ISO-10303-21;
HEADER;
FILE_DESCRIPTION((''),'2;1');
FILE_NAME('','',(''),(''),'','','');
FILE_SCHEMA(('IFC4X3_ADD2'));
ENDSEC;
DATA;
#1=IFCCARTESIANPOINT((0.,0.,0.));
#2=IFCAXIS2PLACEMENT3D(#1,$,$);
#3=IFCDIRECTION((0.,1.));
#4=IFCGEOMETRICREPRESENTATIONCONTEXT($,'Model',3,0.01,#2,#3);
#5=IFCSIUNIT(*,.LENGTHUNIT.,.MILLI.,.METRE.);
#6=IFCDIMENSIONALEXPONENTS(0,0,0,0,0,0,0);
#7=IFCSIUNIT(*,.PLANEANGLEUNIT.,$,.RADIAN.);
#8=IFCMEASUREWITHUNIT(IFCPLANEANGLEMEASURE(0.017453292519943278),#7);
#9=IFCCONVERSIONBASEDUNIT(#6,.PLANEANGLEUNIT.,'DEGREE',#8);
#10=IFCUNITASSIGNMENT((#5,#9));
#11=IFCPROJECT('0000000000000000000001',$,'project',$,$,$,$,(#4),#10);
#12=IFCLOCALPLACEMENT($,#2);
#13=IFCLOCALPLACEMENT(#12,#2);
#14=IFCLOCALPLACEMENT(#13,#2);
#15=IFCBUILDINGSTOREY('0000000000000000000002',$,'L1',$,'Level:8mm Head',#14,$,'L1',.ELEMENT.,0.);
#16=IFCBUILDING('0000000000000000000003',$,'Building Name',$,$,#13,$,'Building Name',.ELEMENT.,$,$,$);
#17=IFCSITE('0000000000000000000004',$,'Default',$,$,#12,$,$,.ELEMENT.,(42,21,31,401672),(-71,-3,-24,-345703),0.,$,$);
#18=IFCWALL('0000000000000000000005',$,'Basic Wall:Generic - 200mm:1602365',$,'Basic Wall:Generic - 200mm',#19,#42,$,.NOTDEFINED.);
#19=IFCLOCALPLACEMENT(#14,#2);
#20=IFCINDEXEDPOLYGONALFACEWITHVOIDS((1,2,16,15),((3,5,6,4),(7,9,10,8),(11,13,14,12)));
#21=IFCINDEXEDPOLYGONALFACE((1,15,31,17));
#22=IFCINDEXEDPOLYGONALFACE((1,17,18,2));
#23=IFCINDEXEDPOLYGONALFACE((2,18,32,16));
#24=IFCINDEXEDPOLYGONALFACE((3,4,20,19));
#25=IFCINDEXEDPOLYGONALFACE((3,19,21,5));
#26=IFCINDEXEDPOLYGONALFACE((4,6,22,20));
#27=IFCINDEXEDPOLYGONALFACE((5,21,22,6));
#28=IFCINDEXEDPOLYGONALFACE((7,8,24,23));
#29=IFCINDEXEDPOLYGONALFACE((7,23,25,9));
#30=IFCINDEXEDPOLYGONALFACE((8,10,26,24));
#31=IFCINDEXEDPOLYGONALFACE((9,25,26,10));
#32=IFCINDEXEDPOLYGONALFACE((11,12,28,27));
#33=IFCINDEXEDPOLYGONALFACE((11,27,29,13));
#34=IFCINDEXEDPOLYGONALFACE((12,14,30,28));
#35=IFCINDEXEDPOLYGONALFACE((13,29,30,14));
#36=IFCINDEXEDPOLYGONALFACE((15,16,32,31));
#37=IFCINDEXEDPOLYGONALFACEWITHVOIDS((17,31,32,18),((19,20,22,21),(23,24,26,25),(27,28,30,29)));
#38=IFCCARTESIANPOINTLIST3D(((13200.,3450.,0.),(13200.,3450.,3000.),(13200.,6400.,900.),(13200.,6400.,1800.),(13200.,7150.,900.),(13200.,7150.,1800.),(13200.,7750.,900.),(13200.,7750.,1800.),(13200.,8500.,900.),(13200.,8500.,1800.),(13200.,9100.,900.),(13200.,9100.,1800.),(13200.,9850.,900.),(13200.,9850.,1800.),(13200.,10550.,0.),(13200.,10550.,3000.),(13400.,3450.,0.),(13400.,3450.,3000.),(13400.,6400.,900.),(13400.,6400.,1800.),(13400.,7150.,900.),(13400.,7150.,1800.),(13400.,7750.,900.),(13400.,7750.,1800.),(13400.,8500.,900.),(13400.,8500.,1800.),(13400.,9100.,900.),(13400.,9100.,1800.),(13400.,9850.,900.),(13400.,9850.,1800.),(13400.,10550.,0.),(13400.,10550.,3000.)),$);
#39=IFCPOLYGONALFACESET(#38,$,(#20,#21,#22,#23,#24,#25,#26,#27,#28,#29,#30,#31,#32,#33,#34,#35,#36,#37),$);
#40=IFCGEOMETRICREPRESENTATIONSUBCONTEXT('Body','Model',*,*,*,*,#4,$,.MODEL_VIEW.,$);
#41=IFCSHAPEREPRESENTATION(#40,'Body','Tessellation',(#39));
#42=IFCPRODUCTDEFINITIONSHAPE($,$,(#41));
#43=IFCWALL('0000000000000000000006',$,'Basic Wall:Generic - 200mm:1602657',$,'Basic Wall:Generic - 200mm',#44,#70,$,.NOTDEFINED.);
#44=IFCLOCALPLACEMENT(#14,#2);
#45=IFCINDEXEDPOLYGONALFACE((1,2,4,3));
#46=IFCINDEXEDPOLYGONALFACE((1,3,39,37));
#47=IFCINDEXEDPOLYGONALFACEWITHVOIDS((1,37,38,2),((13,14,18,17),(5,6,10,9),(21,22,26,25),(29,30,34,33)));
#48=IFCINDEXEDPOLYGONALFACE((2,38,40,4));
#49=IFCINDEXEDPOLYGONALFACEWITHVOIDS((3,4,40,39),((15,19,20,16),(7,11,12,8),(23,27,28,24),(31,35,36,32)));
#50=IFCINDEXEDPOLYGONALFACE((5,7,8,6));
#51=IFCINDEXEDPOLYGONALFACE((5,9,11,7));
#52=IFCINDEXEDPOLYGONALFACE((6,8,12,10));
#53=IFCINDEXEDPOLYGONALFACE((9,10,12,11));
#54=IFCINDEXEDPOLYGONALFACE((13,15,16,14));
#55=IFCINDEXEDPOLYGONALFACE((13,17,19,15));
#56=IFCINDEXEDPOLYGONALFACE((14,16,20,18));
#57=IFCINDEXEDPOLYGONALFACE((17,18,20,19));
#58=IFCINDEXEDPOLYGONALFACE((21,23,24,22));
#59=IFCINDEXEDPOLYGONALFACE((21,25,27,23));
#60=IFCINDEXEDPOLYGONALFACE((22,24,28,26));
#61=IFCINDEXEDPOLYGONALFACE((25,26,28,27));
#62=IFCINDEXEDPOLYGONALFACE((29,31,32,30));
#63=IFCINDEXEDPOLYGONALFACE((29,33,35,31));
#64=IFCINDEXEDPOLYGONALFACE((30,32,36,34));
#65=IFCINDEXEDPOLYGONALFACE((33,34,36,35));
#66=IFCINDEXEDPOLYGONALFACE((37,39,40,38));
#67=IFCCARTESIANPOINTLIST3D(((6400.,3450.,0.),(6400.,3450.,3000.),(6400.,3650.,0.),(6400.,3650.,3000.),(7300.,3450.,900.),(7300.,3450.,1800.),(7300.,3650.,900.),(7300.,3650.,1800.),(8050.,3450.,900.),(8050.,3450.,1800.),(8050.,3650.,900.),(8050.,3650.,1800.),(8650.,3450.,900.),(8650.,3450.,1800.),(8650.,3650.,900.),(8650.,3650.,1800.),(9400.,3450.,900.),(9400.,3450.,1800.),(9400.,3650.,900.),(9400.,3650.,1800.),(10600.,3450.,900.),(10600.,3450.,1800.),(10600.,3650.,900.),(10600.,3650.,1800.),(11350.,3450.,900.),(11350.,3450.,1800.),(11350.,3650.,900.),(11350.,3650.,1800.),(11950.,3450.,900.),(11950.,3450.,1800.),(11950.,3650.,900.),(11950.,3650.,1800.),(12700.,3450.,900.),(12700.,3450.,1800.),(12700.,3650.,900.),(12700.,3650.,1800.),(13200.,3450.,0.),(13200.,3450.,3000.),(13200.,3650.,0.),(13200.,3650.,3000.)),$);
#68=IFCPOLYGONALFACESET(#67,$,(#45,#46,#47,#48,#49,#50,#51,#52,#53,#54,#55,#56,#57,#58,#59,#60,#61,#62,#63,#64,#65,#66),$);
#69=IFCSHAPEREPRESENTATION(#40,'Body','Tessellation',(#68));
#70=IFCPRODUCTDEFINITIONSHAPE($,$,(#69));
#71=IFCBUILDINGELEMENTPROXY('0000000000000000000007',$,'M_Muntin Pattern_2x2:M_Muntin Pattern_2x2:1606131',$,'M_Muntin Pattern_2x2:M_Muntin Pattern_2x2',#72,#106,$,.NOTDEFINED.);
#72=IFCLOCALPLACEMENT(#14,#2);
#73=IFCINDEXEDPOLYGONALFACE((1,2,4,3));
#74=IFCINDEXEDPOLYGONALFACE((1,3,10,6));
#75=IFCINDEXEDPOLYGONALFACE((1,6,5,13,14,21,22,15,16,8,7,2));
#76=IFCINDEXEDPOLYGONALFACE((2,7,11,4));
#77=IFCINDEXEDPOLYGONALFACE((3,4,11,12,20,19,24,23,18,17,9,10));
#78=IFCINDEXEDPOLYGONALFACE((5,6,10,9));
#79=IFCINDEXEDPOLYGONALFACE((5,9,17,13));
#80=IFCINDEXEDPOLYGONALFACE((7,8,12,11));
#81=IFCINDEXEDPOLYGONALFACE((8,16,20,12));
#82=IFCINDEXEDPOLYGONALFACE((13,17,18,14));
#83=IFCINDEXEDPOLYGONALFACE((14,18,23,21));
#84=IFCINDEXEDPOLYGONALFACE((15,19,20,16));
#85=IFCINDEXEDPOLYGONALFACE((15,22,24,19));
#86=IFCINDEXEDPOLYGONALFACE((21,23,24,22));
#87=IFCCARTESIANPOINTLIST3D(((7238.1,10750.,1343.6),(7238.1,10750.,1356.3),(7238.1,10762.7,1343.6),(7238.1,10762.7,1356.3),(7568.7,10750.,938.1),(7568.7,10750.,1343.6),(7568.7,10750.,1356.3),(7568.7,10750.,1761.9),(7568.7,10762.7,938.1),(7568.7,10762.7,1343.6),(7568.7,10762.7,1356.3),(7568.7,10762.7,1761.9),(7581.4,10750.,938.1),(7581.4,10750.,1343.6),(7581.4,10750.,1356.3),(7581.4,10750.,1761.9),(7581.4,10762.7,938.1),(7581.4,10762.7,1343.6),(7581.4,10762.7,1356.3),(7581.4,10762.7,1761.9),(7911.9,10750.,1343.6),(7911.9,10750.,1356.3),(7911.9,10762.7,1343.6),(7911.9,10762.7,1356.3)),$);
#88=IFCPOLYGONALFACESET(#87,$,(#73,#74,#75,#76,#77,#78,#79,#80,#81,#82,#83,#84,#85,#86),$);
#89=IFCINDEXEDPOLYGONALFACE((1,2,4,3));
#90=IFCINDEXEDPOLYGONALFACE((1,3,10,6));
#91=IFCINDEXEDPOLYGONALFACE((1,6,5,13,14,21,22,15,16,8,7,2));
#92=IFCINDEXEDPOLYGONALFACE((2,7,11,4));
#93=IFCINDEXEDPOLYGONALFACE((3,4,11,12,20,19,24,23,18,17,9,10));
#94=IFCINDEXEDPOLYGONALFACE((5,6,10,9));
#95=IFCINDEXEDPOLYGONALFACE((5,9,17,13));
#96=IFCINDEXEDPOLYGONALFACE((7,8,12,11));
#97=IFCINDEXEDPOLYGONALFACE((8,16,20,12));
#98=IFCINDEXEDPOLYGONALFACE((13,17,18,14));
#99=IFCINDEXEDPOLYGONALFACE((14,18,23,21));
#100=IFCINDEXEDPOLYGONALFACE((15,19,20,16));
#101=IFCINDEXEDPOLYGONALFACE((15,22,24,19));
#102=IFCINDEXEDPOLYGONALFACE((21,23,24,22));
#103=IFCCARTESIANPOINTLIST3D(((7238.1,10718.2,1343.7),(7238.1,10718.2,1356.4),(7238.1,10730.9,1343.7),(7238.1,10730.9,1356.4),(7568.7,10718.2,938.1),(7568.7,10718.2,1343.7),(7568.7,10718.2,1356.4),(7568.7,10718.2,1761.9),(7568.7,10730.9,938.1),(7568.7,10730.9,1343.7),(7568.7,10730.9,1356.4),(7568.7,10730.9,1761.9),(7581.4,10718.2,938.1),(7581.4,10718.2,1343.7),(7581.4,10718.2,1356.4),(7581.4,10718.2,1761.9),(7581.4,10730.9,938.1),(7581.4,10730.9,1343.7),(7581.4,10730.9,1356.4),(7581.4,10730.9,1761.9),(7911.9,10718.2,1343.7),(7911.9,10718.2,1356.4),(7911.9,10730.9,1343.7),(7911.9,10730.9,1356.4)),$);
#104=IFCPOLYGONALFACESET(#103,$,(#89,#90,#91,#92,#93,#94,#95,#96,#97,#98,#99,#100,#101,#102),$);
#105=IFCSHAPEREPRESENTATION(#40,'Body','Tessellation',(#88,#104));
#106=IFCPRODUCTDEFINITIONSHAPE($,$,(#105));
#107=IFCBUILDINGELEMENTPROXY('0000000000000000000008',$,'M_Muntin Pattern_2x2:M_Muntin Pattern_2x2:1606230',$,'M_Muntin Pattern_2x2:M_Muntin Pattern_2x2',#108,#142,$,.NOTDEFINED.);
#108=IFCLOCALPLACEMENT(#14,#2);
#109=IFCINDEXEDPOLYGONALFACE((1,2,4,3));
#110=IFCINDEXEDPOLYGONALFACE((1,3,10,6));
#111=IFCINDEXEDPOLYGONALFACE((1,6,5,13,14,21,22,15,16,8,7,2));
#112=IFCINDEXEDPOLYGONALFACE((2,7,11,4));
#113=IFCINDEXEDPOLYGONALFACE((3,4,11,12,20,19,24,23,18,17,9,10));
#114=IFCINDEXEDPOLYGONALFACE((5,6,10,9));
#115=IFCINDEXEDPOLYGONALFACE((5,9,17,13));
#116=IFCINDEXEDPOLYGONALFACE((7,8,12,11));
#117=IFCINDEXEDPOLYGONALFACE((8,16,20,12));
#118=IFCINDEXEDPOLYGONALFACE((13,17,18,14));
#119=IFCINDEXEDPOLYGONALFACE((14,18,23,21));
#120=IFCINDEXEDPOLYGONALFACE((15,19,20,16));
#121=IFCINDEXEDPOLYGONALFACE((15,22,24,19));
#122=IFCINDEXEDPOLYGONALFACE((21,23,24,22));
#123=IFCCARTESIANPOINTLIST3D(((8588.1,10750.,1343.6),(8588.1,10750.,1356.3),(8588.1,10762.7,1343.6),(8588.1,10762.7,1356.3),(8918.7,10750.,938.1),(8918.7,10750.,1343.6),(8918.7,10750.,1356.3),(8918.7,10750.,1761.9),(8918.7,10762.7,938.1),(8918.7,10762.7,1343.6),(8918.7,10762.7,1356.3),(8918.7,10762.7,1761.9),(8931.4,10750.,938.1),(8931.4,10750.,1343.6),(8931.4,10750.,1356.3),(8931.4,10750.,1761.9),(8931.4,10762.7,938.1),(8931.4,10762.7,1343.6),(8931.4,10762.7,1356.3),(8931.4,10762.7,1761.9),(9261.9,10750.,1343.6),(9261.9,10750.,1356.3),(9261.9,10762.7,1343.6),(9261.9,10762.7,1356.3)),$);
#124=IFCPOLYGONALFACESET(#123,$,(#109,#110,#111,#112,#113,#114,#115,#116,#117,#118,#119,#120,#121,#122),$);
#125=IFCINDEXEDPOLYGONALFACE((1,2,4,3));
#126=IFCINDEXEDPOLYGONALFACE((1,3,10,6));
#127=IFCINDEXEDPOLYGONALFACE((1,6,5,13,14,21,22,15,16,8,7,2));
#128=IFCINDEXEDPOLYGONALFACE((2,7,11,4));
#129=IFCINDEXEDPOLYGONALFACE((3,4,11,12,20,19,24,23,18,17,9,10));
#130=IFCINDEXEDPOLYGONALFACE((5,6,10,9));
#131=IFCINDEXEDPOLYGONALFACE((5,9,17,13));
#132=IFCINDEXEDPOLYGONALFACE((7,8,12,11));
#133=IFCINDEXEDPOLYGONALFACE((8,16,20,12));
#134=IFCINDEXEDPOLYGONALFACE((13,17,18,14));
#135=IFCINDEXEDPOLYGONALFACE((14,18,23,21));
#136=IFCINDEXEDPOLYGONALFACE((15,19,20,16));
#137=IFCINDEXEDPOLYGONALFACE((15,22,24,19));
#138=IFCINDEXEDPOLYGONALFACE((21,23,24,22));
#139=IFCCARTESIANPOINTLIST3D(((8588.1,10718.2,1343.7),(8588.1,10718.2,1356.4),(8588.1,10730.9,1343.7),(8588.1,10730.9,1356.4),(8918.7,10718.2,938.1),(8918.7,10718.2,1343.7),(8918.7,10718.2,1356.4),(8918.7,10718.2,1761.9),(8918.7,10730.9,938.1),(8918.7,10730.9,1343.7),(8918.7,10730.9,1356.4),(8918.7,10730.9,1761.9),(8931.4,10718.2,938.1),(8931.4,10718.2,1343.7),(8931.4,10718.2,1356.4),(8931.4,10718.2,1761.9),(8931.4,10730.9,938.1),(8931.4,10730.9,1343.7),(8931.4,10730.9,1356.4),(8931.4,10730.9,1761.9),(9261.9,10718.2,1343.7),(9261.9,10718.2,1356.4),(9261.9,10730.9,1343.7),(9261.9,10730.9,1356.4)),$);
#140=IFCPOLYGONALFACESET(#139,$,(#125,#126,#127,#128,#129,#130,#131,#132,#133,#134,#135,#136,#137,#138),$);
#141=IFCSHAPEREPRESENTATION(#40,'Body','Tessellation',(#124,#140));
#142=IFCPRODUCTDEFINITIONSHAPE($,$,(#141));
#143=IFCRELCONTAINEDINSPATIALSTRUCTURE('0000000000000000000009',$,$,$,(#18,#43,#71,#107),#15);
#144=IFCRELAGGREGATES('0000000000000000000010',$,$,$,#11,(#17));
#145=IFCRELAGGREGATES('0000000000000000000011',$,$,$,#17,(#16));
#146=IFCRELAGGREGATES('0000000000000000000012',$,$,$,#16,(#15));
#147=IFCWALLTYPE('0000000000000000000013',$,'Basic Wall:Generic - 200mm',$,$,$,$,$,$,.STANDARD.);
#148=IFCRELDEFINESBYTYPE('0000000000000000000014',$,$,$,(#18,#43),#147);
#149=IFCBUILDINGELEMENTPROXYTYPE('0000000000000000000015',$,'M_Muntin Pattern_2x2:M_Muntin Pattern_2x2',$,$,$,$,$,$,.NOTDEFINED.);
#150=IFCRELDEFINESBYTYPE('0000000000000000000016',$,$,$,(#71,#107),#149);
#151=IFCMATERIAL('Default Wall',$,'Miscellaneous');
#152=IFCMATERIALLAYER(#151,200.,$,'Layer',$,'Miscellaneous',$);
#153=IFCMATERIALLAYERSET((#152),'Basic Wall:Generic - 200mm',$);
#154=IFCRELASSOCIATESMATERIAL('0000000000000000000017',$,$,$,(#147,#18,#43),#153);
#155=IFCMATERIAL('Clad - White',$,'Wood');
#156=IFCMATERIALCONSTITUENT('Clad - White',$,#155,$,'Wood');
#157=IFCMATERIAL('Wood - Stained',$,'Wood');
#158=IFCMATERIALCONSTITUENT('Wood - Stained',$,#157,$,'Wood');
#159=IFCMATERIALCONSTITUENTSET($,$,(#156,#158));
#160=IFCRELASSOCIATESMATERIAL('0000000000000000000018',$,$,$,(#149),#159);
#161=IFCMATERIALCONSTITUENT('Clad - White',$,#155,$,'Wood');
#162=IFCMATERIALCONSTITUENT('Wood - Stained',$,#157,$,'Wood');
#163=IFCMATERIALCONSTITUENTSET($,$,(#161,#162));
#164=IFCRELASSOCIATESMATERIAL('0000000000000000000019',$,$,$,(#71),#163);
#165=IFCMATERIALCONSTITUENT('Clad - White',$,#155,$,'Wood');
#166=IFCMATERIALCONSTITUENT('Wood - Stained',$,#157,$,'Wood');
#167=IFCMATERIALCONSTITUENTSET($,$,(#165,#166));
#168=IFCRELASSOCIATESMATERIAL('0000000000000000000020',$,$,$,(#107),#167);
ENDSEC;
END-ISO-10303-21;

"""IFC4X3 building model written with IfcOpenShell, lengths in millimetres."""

from ifc_helpers import new_model, entity, si_unit, converted_unit, direction, frame, frame_2d, origin, place, context, subcontext, project, spatial, polyline, rectangle, outline, extrude, source, transform, mapped, material, layer, layer_set, constituent, constituent_set, type_object, type_shapes, element, save


model = new_model("IFC4X3")

# Units and contexts
model_context = context("Model", 3, precision=0.01, world=origin(), true_north=direction((0.0, 1.0)))
body_context = subcontext(model_context, "Body", "Model", "MODEL_VIEW")
ifc_project = project(units=[si_unit("LENGTHUNIT", "METRE", prefix="MILLI"), converted_unit("PLANEANGLEUNIT", "DEGREE", entity("IfcPlaneAngleMeasure", 0.017453292519943278), si_unit("PLANEANGLEUNIT", "RADIAN"), dimensions=[0, 0, 0, 0, 0, 0, 0])], contexts=[model_context])

# Site, building, storey
site_placement = place(None, origin())
site = spatial("IfcSite", under=ifc_project, at=site_placement, Name="Default", CompositionType="ELEMENT", RefLatitude=(42, 21, 31, 401672), RefLongitude=(-71, -3, -24, -345703), RefElevation=0.0)
building_placement = place(site_placement, origin())
building = spatial("IfcBuilding", under=site, at=building_placement, Name="Building Name", LongName="Building Name", CompositionType="ELEMENT")
storey_placement = place(building_placement, origin())
storey = spatial("IfcBuildingStorey", under=building, at=storey_placement, Name="L1", ObjectType="Level:8mm Head", LongName="L1", CompositionType="ELEMENT", Elevation=0.0)

# Walls, openings
ifc_material_1 = material(Name="Default Wall", Category="Miscellaneous")
ifc_layer = layer(ifc_material_1, 200.0, Name="Layer", Category="Miscellaneous")
ifc_layer_set = layer_set([ifc_layer], Name="Basic Wall:Generic - 200mm")
wall_type = type_object("IfcWallType", Name="Basic Wall:Generic - 200mm", PredefinedType="STANDARD", material=ifc_layer_set)
wall_1_placement = place(storey_placement, frame((13300.0, 10550.0, 0.0), z_axis=(0.0, 0.0, 1.0), x_axis=(0.0, -1.0, 0.0)))
wall_1 = element("IfcWall", 1, at=wall_1_placement, inside=storey, type_object=wall_type, material=ifc_layer_set, Name="Basic Wall:Generic - 200mm:1602365", ObjectType="Basic Wall:Generic - 200mm", PredefinedType="NOTDEFINED", context=body_context, shape_type="SweptSolid", body=[
    extrude(rectangle(XDim=7100.0, YDim=200.0, at=frame_2d((3550.0, 0.0), x_axis=(-1.0, 0.0))), origin(), (0.0, 0.0, 1.0), 3000.0),
])
opening_1_placement = place(wall_1_placement, frame((700.0, -100.0, 900.0)))
element("IfcOpeningElement", 2, at=opening_1_placement, cuts=wall_1, PredefinedType="OPENING", context=body_context, shape_type="SweptSolid", body=[
    extrude(rectangle(XDim=900.0, YDim=750.0, at=frame_2d((450.0, 375.0), x_axis=(-1.0, 0.0))), frame((0.0, 0.0, 0.0), z_axis=(0.0, 1.0, 0.0), x_axis=(0.0, 0.0, 1.0)), (0.0, 0.0, 1.0), 200.0),
])
opening_2_placement = place(wall_1_placement, frame((2050.0, -100.0, 900.0)))
element("IfcOpeningElement", 3, at=opening_2_placement, cuts=wall_1, PredefinedType="OPENING", context=body_context, shape_type="SweptSolid", body=[
    extrude(rectangle(XDim=900.0, YDim=750.0, at=frame_2d((450.0, 375.0), x_axis=(-1.0, 0.0))), frame((0.0, 0.0, 0.0), z_axis=(0.0, 1.0, 0.0), x_axis=(0.0, 0.0, 1.0)), (0.0, 0.0, 1.0), 200.0),
])
opening_3_placement = place(wall_1_placement, frame((3400.0, -100.0, 900.0)))
element("IfcOpeningElement", 4, at=opening_3_placement, cuts=wall_1, PredefinedType="OPENING", context=body_context, shape_type="SweptSolid", body=[
    extrude(rectangle(XDim=900.0, YDim=750.0, at=frame_2d((450.0, 375.0), x_axis=(-1.0, 0.0))), frame((0.0, 0.0, 0.0), z_axis=(0.0, 1.0, 0.0), x_axis=(0.0, 0.0, 1.0)), (0.0, 0.0, 1.0), 200.0),
])
wall_2_placement = place(storey_placement, frame((6400.0, 3550.0, 0.0)))
wall_2 = element("IfcWall", 5, at=wall_2_placement, inside=storey, type_object=wall_type, material=ifc_layer_set, Name="Basic Wall:Generic - 200mm:1602657", ObjectType="Basic Wall:Generic - 200mm", PredefinedType="NOTDEFINED", context=body_context, shape_type="SweptSolid", body=[
    extrude(rectangle(XDim=6800.0, YDim=200.0, at=frame_2d((3400.0, 0.0), x_axis=(-1.0, 0.0))), origin(), (0.0, 0.0, 1.0), 3000.0),
])
opening_4_placement = place(wall_2_placement, frame((1650.0, 100.0, 900.0)))
element("IfcOpeningElement", 6, at=opening_4_placement, cuts=wall_2, PredefinedType="OPENING", context=body_context, shape_type="SweptSolid", body=[
    extrude(rectangle(XDim=900.0, YDim=750.0, at=frame_2d((450.0, 375.0), x_axis=(-1.0, 0.0))), frame((0.0, 0.0, 0.0), z_axis=(0.0, -1.0, 0.0), x_axis=(0.0, 0.0, 1.0)), (0.0, 0.0, 1.0), 200.0),
])
opening_5_placement = place(wall_2_placement, frame((3000.0, 100.0, 900.0)))
element("IfcOpeningElement", 7, at=opening_5_placement, cuts=wall_2, PredefinedType="OPENING", context=body_context, shape_type="SweptSolid", body=[
    extrude(rectangle(XDim=900.0, YDim=750.0, at=frame_2d((450.0, 375.0), x_axis=(-1.0, 0.0))), frame((0.0, 0.0, 0.0), z_axis=(0.0, -1.0, 0.0), x_axis=(0.0, 0.0, 1.0)), (0.0, 0.0, 1.0), 200.0),
])
opening_6_placement = place(wall_2_placement, frame((4950.0, 100.0, 900.0)))
element("IfcOpeningElement", 8, at=opening_6_placement, cuts=wall_2, PredefinedType="OPENING", context=body_context, shape_type="SweptSolid", body=[
    extrude(rectangle(XDim=900.0, YDim=750.0, at=frame_2d((450.0, 375.0), x_axis=(-1.0, 0.0))), frame((0.0, 0.0, 0.0), z_axis=(0.0, -1.0, 0.0), x_axis=(0.0, 0.0, 1.0)), (0.0, 0.0, 1.0), 200.0),
])
opening_7_placement = place(wall_2_placement, frame((6300.0, 100.0, 900.0)))
element("IfcOpeningElement", 9, at=opening_7_placement, cuts=wall_2, PredefinedType="OPENING", context=body_context, shape_type="SweptSolid", body=[
    extrude(rectangle(XDim=900.0, YDim=750.0, at=frame_2d((450.0, 375.0), x_axis=(-1.0, 0.0))), frame((0.0, 0.0, 0.0), z_axis=(0.0, -1.0, 0.0), x_axis=(0.0, 0.0, 1.0)), (0.0, 0.0, 1.0), 200.0),
])

# Building element proxies
ifc_material_2 = material(Name="Clad - White", Category="Wood")
ifc_constituent_1 = constituent(ifc_material_2, Name="Clad - White", Category="Wood")
ifc_material_3 = material(Name="Wood - Stained", Category="Wood")
ifc_constituent_2 = constituent(ifc_material_3, Name="Wood - Stained", Category="Wood")
ifc_constituent_set_1 = constituent_set(constituents=[ifc_constituent_1, ifc_constituent_2])
ifc_constituent_3 = constituent(ifc_material_2, Name="Clad - White", Category="Wood")
ifc_constituent_4 = constituent(ifc_material_3, Name="Wood - Stained", Category="Wood")
ifc_constituent_set_2 = constituent_set(constituents=[ifc_constituent_3, ifc_constituent_4])
building_element_proxy_type_1 = type_object("IfcBuildingElementProxyType", Name="M_Muntin Pattern_2x2:M_Muntin Pattern_2x2", PredefinedType="NOTDEFINED", material=ifc_constituent_set_2)
shared_shape_1 = source(origin(), body_context, "Body", "SweptSolid", [
    extrude(outline(polyline([(6.4, -6.4), (411.9, -6.4), (411.9, 6.3), (6.4, 6.3), (6.4, 336.9), (-6.3, 336.9), (-6.3, 6.3), (-411.9, 6.3), (-411.9, -6.4), (-6.3, -6.4), (-6.3, -336.9), (6.4, -336.9), (6.4, -6.4)])), frame((0.0, -22.2, 411.9), z_axis=(0.0, 1.0, 0.0), x_axis=(0.0, 0.0, 1.0)), (0.0, 0.0, 1.0), 12.7),
    extrude(outline(polyline([(6.4, -6.4), (411.9, -6.4), (411.9, 6.3), (6.4, 6.3), (6.4, 336.9), (-6.3, 336.9), (-6.3, 6.3), (-411.9, 6.3), (-411.9, -6.4), (-6.3, -6.4), (-6.3, -336.9), (6.4, -336.9), (6.4, -6.4)])), frame((0.0, 9.5, 411.9), z_axis=(0.0, 1.0, 0.0), x_axis=(0.0, 0.0, 1.0)), (0.0, 0.0, 1.0), 12.7),
])
type_shapes(building_element_proxy_type_1, [shared_shape_1])
proxy_1_placement = place(storey_placement, frame((7575.0, 10740.5, 938.1), z_axis=(0.0, 0.0, 1.0), x_axis=(-1.0, 0.0, 0.0)))
element("IfcBuildingElementProxy", 10, at=proxy_1_placement, inside=storey, type_object=building_element_proxy_type_1, material=ifc_constituent_set_1, Name="M_Muntin Pattern_2x2:M_Muntin Pattern_2x2:1606131", ObjectType="M_Muntin Pattern_2x2:M_Muntin Pattern_2x2", PredefinedType="NOTDEFINED", context=body_context, shape_type="MappedRepresentation", body=[
    mapped(shared_shape_1, transform((0.0, 0.0, 0.0), scale=1.0)),
])
ifc_constituent_5 = constituent(ifc_material_2, Name="Clad - White", Category="Wood")
ifc_constituent_6 = constituent(ifc_material_3, Name="Wood - Stained", Category="Wood")
ifc_constituent_set_3 = constituent_set(constituents=[ifc_constituent_5, ifc_constituent_6])
proxy_2_placement = place(storey_placement, frame((8925.0, 10740.5, 938.1), z_axis=(0.0, 0.0, 1.0), x_axis=(-1.0, 0.0, 0.0)))
element("IfcBuildingElementProxy", 11, at=proxy_2_placement, inside=storey, type_object=building_element_proxy_type_1, material=ifc_constituent_set_3, Name="M_Muntin Pattern_2x2:M_Muntin Pattern_2x2:1606230", ObjectType="M_Muntin Pattern_2x2:M_Muntin Pattern_2x2", PredefinedType="NOTDEFINED", context=body_context, shape_type="MappedRepresentation", body=[
    mapped(shared_shape_1, transform((0.0, 0.0, 0.0), scale=1.0)),
])

save(model, "model.ifc")
